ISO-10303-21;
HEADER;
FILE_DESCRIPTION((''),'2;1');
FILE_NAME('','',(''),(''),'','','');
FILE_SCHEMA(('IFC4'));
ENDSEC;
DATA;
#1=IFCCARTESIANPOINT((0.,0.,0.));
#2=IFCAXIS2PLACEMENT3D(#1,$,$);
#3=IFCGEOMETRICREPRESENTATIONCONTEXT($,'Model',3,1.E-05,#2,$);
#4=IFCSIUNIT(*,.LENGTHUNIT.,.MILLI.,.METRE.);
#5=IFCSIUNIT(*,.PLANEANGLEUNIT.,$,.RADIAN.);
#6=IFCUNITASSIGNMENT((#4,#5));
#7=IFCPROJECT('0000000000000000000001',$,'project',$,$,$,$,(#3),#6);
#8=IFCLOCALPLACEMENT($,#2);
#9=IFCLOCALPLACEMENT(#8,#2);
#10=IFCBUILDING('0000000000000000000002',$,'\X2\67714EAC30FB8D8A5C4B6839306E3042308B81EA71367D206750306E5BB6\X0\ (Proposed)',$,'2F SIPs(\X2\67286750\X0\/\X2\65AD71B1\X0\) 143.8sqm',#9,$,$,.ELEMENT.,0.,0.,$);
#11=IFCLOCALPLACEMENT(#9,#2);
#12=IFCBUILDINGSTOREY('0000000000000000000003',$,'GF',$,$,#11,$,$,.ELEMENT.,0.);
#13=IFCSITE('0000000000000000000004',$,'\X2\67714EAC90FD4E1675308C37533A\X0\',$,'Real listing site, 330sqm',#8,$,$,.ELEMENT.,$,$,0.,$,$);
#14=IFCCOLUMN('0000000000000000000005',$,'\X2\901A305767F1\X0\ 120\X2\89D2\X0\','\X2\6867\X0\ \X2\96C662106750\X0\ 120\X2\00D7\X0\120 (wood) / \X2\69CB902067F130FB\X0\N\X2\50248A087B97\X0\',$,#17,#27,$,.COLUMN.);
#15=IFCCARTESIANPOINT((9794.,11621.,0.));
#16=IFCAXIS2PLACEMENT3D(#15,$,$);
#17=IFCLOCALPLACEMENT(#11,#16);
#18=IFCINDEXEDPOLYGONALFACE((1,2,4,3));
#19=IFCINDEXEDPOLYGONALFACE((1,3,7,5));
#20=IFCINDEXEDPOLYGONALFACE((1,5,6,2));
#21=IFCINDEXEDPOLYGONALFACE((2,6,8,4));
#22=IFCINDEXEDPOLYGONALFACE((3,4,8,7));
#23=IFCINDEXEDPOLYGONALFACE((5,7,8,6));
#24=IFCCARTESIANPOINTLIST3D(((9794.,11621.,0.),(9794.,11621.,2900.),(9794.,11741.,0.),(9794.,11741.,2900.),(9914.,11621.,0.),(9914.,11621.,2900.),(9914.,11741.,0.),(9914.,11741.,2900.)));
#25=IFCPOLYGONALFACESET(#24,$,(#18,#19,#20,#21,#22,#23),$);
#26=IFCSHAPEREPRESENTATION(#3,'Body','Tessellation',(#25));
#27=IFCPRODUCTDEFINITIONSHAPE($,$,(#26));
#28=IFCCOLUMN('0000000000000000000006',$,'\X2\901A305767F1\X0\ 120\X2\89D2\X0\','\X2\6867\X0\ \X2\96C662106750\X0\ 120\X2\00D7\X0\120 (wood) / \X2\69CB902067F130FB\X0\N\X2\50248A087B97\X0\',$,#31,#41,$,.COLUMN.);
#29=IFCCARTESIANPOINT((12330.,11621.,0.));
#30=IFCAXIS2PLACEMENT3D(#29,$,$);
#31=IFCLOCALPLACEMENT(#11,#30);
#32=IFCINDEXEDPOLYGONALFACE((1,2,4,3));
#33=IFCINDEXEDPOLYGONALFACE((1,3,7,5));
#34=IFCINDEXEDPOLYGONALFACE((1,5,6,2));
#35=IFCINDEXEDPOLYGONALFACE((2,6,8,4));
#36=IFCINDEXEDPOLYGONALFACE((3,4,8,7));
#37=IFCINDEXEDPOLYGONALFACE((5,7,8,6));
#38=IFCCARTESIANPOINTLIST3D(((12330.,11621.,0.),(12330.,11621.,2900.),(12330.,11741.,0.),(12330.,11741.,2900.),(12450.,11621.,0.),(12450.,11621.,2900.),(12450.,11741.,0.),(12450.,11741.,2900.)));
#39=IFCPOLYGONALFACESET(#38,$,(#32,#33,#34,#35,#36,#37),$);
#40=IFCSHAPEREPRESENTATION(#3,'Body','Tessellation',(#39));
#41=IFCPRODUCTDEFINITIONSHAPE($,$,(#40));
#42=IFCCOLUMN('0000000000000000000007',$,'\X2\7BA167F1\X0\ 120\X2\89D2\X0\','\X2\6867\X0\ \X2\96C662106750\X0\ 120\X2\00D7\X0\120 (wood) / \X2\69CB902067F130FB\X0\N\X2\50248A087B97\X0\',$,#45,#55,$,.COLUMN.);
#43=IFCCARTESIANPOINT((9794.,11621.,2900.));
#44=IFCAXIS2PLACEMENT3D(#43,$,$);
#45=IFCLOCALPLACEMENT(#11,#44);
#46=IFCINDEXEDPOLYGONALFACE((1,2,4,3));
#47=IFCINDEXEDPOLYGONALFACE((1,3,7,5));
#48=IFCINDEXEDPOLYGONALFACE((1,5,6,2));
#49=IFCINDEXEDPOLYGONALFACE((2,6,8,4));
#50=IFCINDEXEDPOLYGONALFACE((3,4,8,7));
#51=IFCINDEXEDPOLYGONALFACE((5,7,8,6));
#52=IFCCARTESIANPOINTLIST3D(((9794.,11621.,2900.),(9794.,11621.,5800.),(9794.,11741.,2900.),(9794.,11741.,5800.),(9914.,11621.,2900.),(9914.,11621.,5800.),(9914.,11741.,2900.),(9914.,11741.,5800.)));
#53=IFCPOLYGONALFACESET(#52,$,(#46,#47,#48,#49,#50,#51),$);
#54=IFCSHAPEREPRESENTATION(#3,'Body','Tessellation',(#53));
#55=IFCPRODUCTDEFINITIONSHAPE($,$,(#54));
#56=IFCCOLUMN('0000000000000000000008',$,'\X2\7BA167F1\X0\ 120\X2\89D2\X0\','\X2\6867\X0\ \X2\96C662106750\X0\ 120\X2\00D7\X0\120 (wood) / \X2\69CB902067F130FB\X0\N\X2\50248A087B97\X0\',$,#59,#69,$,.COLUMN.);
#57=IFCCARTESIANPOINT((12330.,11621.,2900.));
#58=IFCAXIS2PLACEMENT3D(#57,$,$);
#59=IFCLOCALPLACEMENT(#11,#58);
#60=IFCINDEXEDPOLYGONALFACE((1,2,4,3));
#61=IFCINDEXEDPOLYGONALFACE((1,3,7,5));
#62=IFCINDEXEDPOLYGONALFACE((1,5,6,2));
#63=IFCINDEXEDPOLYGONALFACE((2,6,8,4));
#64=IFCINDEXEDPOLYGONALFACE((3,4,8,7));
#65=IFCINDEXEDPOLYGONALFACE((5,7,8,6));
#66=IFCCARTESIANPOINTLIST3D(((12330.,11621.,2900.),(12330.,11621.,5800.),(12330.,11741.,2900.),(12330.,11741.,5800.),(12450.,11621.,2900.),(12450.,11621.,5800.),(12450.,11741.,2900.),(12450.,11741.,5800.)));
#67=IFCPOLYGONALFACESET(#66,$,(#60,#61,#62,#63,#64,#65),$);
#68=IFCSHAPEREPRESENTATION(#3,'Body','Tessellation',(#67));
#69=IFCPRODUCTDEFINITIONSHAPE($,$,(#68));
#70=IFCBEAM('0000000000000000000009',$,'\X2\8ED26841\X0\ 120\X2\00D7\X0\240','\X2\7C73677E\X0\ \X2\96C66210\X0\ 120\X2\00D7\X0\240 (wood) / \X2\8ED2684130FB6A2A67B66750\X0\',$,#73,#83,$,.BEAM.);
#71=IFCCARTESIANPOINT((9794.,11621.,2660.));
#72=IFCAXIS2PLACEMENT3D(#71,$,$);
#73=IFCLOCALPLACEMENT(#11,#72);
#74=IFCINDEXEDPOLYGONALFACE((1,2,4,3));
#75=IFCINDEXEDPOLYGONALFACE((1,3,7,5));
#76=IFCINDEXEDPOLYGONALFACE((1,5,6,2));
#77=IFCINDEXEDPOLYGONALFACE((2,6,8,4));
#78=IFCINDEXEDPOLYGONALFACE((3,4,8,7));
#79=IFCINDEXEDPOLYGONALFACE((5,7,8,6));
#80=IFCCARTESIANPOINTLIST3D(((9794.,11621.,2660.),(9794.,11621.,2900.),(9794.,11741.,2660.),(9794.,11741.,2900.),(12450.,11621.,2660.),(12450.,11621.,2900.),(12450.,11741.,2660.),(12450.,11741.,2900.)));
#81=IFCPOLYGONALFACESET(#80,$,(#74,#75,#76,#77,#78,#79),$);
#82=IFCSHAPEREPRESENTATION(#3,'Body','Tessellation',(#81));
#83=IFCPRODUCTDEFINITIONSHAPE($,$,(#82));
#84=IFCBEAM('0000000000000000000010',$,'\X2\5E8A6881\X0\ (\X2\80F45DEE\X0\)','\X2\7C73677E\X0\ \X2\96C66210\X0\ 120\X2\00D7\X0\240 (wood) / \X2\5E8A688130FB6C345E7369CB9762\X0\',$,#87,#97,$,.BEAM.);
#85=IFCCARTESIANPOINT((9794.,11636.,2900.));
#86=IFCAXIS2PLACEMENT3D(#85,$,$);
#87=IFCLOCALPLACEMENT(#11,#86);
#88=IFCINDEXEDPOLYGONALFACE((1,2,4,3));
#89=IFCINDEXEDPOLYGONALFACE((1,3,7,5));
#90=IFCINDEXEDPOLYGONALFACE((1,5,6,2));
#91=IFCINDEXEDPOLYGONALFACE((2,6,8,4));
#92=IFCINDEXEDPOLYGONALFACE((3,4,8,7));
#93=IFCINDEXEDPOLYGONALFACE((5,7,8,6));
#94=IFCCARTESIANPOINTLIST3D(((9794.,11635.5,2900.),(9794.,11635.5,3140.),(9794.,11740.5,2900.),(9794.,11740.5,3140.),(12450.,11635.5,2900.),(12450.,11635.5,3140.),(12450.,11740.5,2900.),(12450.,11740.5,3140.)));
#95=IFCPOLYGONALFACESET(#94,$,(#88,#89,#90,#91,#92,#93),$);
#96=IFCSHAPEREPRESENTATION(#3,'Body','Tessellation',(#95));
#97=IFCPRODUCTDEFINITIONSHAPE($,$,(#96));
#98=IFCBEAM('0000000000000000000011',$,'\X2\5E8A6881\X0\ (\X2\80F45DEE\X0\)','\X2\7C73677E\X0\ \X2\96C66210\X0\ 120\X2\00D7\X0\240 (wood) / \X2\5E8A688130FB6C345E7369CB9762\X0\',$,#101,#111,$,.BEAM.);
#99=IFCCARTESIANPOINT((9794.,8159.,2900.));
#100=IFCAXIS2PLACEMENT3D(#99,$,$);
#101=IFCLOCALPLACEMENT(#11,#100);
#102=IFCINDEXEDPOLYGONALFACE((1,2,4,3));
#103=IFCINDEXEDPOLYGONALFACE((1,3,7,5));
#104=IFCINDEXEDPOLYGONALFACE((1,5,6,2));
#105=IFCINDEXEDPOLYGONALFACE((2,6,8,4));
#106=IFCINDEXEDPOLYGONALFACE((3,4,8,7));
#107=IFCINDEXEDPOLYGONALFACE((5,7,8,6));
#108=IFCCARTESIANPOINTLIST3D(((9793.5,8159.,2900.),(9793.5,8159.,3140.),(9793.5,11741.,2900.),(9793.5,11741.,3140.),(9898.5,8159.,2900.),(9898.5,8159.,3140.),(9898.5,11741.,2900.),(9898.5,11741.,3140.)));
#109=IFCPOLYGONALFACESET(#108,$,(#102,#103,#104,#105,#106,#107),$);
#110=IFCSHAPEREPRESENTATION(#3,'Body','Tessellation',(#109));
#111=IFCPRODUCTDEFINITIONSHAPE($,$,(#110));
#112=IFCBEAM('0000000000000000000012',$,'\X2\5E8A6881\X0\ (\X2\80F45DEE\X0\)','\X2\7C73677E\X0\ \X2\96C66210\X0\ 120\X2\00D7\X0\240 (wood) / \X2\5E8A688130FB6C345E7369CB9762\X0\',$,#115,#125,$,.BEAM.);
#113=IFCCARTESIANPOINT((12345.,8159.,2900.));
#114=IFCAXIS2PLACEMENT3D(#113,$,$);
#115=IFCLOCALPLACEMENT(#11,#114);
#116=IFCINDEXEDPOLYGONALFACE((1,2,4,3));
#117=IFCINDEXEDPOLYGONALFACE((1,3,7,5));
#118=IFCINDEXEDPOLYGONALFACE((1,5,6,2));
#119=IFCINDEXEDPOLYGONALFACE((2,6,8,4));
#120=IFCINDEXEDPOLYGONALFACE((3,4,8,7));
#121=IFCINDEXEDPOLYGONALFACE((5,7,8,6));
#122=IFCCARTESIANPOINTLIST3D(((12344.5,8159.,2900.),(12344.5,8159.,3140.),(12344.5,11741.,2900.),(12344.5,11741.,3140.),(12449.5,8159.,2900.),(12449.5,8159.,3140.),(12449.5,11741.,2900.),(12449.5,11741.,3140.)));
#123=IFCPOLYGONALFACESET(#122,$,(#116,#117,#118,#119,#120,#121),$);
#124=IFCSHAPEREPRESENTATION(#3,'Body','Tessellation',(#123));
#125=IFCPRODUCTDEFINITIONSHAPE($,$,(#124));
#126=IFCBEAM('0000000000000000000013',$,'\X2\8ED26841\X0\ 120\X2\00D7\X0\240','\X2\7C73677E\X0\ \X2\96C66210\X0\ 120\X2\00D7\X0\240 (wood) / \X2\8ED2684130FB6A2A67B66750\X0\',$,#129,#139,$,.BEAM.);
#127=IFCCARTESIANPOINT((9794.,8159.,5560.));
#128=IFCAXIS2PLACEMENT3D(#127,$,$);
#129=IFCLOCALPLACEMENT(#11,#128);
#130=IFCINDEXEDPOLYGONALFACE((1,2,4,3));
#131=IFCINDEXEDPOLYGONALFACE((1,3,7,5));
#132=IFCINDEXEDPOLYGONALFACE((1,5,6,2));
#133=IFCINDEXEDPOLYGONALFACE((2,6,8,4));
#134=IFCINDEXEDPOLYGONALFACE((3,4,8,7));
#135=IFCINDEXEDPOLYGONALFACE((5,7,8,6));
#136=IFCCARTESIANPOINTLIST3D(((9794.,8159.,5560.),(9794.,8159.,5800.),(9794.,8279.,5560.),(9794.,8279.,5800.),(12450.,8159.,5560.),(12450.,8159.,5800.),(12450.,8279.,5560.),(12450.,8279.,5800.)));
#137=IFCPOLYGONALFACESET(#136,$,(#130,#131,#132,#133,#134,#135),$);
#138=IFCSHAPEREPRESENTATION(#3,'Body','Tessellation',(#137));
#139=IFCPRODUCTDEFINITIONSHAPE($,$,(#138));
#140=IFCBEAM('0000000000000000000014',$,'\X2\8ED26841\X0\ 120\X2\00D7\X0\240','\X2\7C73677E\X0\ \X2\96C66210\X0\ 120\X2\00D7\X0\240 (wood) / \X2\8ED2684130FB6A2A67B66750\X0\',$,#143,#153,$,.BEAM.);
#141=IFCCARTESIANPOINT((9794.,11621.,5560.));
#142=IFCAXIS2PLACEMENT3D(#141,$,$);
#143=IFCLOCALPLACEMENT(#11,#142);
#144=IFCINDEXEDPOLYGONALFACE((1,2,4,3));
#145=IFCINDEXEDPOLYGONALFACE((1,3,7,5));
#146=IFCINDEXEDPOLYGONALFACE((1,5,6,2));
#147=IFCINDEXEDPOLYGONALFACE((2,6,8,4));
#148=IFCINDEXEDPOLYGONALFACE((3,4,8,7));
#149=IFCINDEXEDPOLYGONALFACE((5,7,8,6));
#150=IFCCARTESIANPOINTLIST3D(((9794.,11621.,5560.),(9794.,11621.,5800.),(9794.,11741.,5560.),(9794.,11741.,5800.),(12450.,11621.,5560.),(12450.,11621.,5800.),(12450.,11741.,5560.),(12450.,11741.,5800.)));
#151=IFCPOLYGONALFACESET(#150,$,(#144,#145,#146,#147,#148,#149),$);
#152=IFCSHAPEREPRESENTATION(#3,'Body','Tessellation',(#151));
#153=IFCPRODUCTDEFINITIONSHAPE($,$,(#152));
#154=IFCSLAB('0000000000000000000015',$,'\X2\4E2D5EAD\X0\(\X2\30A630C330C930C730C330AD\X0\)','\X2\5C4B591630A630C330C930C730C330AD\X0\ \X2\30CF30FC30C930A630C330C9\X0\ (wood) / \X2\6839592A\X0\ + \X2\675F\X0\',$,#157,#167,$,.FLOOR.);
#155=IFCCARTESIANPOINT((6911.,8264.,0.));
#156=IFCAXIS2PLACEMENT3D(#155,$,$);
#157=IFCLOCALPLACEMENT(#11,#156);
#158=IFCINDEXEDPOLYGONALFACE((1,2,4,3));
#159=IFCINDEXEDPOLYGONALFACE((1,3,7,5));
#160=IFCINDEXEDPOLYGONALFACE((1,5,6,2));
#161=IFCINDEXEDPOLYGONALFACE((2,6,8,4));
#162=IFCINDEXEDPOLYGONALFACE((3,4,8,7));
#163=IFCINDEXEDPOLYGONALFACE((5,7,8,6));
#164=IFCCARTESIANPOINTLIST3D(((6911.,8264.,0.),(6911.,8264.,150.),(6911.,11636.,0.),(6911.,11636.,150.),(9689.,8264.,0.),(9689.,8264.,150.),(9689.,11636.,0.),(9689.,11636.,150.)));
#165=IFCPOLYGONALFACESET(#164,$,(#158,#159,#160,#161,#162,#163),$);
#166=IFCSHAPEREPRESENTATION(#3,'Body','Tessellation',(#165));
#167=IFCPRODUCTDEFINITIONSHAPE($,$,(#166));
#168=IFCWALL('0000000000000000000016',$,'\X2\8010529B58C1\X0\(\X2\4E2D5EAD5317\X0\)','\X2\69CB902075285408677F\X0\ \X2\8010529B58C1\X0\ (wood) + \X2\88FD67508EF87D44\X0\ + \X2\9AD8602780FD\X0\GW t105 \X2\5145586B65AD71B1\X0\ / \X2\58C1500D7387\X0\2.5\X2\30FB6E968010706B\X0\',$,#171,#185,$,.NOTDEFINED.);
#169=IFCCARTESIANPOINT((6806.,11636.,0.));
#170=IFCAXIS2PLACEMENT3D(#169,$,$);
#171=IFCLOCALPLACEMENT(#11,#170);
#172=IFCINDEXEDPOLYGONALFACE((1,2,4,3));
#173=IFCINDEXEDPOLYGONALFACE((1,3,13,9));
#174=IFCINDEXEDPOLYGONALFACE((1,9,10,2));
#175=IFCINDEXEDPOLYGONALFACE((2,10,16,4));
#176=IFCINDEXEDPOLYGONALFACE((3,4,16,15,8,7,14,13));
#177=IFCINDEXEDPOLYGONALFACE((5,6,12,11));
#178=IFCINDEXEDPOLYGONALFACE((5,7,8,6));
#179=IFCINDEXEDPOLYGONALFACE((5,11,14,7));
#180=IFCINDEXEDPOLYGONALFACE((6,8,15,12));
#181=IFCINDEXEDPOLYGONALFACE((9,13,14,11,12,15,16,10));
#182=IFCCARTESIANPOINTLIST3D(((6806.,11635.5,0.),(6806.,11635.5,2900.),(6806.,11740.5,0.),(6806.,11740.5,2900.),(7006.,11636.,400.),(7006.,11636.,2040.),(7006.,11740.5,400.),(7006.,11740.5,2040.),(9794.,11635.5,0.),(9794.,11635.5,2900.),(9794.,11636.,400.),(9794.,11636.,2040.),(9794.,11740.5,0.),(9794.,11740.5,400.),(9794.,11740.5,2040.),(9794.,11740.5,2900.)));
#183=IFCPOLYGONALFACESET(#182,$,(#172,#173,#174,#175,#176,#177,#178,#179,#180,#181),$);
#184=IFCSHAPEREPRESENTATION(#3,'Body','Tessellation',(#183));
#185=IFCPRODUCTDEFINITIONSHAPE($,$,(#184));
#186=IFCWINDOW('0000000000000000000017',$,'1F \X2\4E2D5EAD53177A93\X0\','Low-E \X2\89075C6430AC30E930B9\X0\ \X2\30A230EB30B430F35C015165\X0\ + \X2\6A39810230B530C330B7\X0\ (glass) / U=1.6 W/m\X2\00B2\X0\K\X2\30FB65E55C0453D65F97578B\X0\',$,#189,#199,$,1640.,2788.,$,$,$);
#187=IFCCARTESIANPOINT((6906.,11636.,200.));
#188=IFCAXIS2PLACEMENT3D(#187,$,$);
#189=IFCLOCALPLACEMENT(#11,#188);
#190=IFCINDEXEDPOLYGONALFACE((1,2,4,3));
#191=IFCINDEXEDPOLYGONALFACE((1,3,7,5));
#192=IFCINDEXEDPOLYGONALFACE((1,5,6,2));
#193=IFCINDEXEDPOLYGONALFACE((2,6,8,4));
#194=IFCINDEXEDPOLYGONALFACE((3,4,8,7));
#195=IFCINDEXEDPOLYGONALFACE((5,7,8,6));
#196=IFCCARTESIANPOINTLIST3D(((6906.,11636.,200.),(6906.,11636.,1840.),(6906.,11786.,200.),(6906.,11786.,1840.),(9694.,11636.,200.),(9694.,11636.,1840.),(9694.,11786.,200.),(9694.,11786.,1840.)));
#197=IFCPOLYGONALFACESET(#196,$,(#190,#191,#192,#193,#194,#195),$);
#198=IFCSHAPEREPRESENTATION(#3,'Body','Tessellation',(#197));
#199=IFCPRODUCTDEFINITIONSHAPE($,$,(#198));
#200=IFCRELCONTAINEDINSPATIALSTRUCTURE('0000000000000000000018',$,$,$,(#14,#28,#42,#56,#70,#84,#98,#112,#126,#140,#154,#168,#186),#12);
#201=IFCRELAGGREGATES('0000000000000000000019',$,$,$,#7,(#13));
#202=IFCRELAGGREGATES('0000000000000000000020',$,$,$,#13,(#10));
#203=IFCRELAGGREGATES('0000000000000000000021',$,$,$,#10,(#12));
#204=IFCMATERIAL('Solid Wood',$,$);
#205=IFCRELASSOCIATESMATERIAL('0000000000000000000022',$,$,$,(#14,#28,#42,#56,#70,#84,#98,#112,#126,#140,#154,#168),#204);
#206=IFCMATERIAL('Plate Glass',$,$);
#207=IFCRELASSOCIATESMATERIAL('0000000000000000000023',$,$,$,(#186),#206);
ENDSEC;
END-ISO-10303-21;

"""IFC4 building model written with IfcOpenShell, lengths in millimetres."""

from ifc_helpers import new_model, si_unit, frame, frame_2d, origin, place, context, project, spatial, rectangle, extrude, material, element, fill, save


model = new_model("IFC4")

# Units and contexts
model_context = context("Model", 3, precision=1e-05, world=origin())
ifc_project = project(units=[si_unit("LENGTHUNIT", "METRE", prefix="MILLI"), si_unit("PLANEANGLEUNIT", "RADIAN")], contexts=[model_context])

# Site, building, storey
site_placement = place(None, origin())
site = spatial("IfcSite", under=ifc_project, at=site_placement, Name="東京都世田谷区", ObjectType="Real listing site, 330sqm", CompositionType="ELEMENT", RefElevation=0.0)
building_placement = place(site_placement, origin())
building = spatial("IfcBuilding", under=site, at=building_placement, Name="東京・越屋根のある自然素材の家 (Proposed)", ObjectType="2F SIPs(木材/断熱) 143.8sqm", CompositionType="ELEMENT", ElevationOfRefHeight=0.0, ElevationOfTerrain=0.0)
storey_placement = place(building_placement, origin())
storey = spatial("IfcBuildingStorey", under=building, at=storey_placement, Name="GF", CompositionType="ELEMENT", Elevation=0.0)

# Columns
ifc_material_1 = material(Name="Solid Wood")
column_1_placement = place(storey_placement, frame((9794.0, 11621.0, 0.0)))
element("IfcColumn", 1, at=column_1_placement, inside=storey, material=ifc_material_1, Name="通し柱 120角", Description="桧 集成材 120×120 (wood) / 構造柱・N値計算", PredefinedType="COLUMN", context=model_context, shape_type="SweptSolid", body=[
    extrude(rectangle(XDim=120.0, YDim=120.0, at=frame_2d((60.0, 60.0))), frame((9794.0, 11621.0, 0.0)), (0.0, 0.0, 1.0), 2900.0),
])
column_2_placement = place(storey_placement, frame((12330.0, 11621.0, 0.0)))
element("IfcColumn", 2, at=column_2_placement, inside=storey, material=ifc_material_1, Name="通し柱 120角", Description="桧 集成材 120×120 (wood) / 構造柱・N値計算", PredefinedType="COLUMN", context=model_context, shape_type="SweptSolid", body=[
    extrude(rectangle(XDim=120.0, YDim=120.0, at=frame_2d((60.0, 60.0))), frame((12330.0, 11621.0, 0.0)), (0.0, 0.0, 1.0), 2900.0),
])
column_3_placement = place(storey_placement, frame((9794.0, 11621.0, 2900.0)))
element("IfcColumn", 3, at=column_3_placement, inside=storey, material=ifc_material_1, Name="管柱 120角", Description="桧 集成材 120×120 (wood) / 構造柱・N値計算", PredefinedType="COLUMN", context=model_context, shape_type="SweptSolid", body=[
    extrude(rectangle(XDim=120.0, YDim=120.0, at=frame_2d((60.0, 60.0))), frame((9794.0, 11621.0, 2900.0)), (0.0, 0.0, 1.0), 2900.0),
])
column_4_placement = place(storey_placement, frame((12330.0, 11621.0, 2900.0)))
element("IfcColumn", 4, at=column_4_placement, inside=storey, material=ifc_material_1, Name="管柱 120角", Description="桧 集成材 120×120 (wood) / 構造柱・N値計算", PredefinedType="COLUMN", context=model_context, shape_type="SweptSolid", body=[
    extrude(rectangle(XDim=120.0, YDim=120.0, at=frame_2d((60.0, 60.0))), frame((12330.0, 11621.0, 2900.0)), (0.0, 0.0, 1.0), 2900.0),
])

# Beams
beam_1_placement = place(storey_placement, frame((9794.0, 11621.0, 2660.0)))
element("IfcBeam", 5, at=beam_1_placement, inside=storey, material=ifc_material_1, Name="軒桁 120×240", Description="米松 集成 120×240 (wood) / 軒桁・横架材", PredefinedType="BEAM", context=model_context, shape_type="SweptSolid", body=[
    extrude(rectangle(XDim=2656.0, YDim=120.0, at=frame_2d((1328.0, 60.0))), frame((9794.0, 11621.0, 2660.0)), (0.0, 0.0, 1.0), 240.0),
])
beam_2_placement = place(storey_placement, frame((9794.0, 11636.0, 2900.0)))
element("IfcBeam", 6, at=beam_2_placement, inside=storey, material=ifc_material_1, Name="床梁 (胴差)", Description="米松 集成 120×240 (wood) / 床梁・水平構面", PredefinedType="BEAM", context=model_context, shape_type="SweptSolid", body=[
    extrude(rectangle(XDim=2656.0, YDim=105.0, at=frame_2d((1328.0, 52.0))), frame((9794.0, 11636.0, 2900.0)), (0.0, 0.0, 1.0), 240.0),
])
beam_3_placement = place(storey_placement, frame((9794.0, 8159.0, 2900.0)))
element("IfcBeam", 7, at=beam_3_placement, inside=storey, material=ifc_material_1, Name="床梁 (胴差)", Description="米松 集成 120×240 (wood) / 床梁・水平構面", PredefinedType="BEAM", context=model_context, shape_type="SweptSolid", body=[
    extrude(rectangle(XDim=105.0, YDim=3582.0, at=frame_2d((52.0, 1791.0))), frame((9794.0, 8159.0, 2900.0)), (0.0, 0.0, 1.0), 240.0),
])
beam_4_placement = place(storey_placement, frame((12345.0, 8159.0, 2900.0)))
element("IfcBeam", 8, at=beam_4_placement, inside=storey, material=ifc_material_1, Name="床梁 (胴差)", Description="米松 集成 120×240 (wood) / 床梁・水平構面", PredefinedType="BEAM", context=model_context, shape_type="SweptSolid", body=[
    extrude(rectangle(XDim=105.0, YDim=3582.0, at=frame_2d((52.0, 1791.0))), frame((12345.0, 8159.0, 2900.0)), (0.0, 0.0, 1.0), 240.0),
])
beam_5_placement = place(storey_placement, frame((9794.0, 8159.0, 5560.0)))
element("IfcBeam", 9, at=beam_5_placement, inside=storey, material=ifc_material_1, Name="軒桁 120×240", Description="米松 集成 120×240 (wood) / 軒桁・横架材", PredefinedType="BEAM", context=model_context, shape_type="SweptSolid", body=[
    extrude(rectangle(XDim=2656.0, YDim=120.0, at=frame_2d((1328.0, 60.0))), frame((9794.0, 8159.0, 5560.0)), (0.0, 0.0, 1.0), 240.0),
])
beam_6_placement = place(storey_placement, frame((9794.0, 11621.0, 5560.0)))
element("IfcBeam", 10, at=beam_6_placement, inside=storey, material=ifc_material_1, Name="軒桁 120×240", Description="米松 集成 120×240 (wood) / 軒桁・横架材", PredefinedType="BEAM", context=model_context, shape_type="SweptSolid", body=[
    extrude(rectangle(XDim=2656.0, YDim=120.0, at=frame_2d((1328.0, 60.0))), frame((9794.0, 11621.0, 5560.0)), (0.0, 0.0, 1.0), 240.0),
])

# Slab
slab_placement = place(storey_placement, frame((6911.0, 8264.0, 0.0)))
element("IfcSlab", 11, at=slab_placement, inside=storey, material=ifc_material_1, Name="中庭(ウッドデッキ)", Description="屋外ウッドデッキ ハードウッド (wood) / 根太 + 束", PredefinedType="FLOOR", context=model_context, shape_type="SweptSolid", body=[
    extrude(rectangle(XDim=2778.0, YDim=3372.0, at=frame_2d((1389.0, 1686.0))), frame((6911.0, 8264.0, 0.0)), (0.0, 0.0, 1.0), 150.0),
])

# Wall, opening, window
wall_1_placement = place(storey_placement, frame((6806.0, 11636.0, 0.0)))
wall_1 = element("IfcWall", 12, at=wall_1_placement, inside=storey, material=ifc_material_1, Name="耐力壁(中庭北)", Description="構造用合板 耐力壁 (wood) + 製材軸組 + 高性能GW t105 充填断熱 / 壁倍率2.5・準耐火", PredefinedType="NOTDEFINED", context=model_context, shape_type="SweptSolid", body=[
    extrude(rectangle(XDim=2988.0, YDim=105.0, at=frame_2d((1494.0, 52.0))), frame((6806.0, 11636.0, 0.0)), (0.0, 0.0, 1.0), 2900.0),
])
opening_1_placement = place(storey_placement, frame((6906.0, 11636.0, 200.0)))
opening_1 = element("IfcOpeningElement", 13, at=opening_1_placement, cuts=wall_1, PredefinedType="NOTDEFINED", context=model_context, shape_type="SweptSolid", body=[
    extrude(rectangle(XDim=2788.0, YDim=150.0, at=frame_2d((1394.0, 75.0))), frame((6906.0, 11636.0, 200.0)), (0.0, 0.0, 1.0), 1640.0),
])
ifc_material_2 = material(Name="Plate Glass")
window_1_placement = place(storey_placement, frame((6906.0, 11636.0, 200.0)))
window_1 = element("IfcWindow", 14, at=window_1_placement, inside=storey, material=ifc_material_2, Name="1F 中庭北窓", Description="Low-E 複層ガラス アルゴン封入 + 樹脂サッシ (glass) / U=1.6 W/m²K・日射取得型", OverallHeight=1640.0, OverallWidth=2788.0, context=model_context, shape_type="SweptSolid", body=[
    extrude(rectangle(XDim=2788.0, YDim=150.0, at=frame_2d((1394.0, 75.0))), frame((6906.0, 11636.0, 200.0)), (0.0, 0.0, 1.0), 1640.0),
])
fill(opening_1, window_1)

save(model, "model.ifc")
